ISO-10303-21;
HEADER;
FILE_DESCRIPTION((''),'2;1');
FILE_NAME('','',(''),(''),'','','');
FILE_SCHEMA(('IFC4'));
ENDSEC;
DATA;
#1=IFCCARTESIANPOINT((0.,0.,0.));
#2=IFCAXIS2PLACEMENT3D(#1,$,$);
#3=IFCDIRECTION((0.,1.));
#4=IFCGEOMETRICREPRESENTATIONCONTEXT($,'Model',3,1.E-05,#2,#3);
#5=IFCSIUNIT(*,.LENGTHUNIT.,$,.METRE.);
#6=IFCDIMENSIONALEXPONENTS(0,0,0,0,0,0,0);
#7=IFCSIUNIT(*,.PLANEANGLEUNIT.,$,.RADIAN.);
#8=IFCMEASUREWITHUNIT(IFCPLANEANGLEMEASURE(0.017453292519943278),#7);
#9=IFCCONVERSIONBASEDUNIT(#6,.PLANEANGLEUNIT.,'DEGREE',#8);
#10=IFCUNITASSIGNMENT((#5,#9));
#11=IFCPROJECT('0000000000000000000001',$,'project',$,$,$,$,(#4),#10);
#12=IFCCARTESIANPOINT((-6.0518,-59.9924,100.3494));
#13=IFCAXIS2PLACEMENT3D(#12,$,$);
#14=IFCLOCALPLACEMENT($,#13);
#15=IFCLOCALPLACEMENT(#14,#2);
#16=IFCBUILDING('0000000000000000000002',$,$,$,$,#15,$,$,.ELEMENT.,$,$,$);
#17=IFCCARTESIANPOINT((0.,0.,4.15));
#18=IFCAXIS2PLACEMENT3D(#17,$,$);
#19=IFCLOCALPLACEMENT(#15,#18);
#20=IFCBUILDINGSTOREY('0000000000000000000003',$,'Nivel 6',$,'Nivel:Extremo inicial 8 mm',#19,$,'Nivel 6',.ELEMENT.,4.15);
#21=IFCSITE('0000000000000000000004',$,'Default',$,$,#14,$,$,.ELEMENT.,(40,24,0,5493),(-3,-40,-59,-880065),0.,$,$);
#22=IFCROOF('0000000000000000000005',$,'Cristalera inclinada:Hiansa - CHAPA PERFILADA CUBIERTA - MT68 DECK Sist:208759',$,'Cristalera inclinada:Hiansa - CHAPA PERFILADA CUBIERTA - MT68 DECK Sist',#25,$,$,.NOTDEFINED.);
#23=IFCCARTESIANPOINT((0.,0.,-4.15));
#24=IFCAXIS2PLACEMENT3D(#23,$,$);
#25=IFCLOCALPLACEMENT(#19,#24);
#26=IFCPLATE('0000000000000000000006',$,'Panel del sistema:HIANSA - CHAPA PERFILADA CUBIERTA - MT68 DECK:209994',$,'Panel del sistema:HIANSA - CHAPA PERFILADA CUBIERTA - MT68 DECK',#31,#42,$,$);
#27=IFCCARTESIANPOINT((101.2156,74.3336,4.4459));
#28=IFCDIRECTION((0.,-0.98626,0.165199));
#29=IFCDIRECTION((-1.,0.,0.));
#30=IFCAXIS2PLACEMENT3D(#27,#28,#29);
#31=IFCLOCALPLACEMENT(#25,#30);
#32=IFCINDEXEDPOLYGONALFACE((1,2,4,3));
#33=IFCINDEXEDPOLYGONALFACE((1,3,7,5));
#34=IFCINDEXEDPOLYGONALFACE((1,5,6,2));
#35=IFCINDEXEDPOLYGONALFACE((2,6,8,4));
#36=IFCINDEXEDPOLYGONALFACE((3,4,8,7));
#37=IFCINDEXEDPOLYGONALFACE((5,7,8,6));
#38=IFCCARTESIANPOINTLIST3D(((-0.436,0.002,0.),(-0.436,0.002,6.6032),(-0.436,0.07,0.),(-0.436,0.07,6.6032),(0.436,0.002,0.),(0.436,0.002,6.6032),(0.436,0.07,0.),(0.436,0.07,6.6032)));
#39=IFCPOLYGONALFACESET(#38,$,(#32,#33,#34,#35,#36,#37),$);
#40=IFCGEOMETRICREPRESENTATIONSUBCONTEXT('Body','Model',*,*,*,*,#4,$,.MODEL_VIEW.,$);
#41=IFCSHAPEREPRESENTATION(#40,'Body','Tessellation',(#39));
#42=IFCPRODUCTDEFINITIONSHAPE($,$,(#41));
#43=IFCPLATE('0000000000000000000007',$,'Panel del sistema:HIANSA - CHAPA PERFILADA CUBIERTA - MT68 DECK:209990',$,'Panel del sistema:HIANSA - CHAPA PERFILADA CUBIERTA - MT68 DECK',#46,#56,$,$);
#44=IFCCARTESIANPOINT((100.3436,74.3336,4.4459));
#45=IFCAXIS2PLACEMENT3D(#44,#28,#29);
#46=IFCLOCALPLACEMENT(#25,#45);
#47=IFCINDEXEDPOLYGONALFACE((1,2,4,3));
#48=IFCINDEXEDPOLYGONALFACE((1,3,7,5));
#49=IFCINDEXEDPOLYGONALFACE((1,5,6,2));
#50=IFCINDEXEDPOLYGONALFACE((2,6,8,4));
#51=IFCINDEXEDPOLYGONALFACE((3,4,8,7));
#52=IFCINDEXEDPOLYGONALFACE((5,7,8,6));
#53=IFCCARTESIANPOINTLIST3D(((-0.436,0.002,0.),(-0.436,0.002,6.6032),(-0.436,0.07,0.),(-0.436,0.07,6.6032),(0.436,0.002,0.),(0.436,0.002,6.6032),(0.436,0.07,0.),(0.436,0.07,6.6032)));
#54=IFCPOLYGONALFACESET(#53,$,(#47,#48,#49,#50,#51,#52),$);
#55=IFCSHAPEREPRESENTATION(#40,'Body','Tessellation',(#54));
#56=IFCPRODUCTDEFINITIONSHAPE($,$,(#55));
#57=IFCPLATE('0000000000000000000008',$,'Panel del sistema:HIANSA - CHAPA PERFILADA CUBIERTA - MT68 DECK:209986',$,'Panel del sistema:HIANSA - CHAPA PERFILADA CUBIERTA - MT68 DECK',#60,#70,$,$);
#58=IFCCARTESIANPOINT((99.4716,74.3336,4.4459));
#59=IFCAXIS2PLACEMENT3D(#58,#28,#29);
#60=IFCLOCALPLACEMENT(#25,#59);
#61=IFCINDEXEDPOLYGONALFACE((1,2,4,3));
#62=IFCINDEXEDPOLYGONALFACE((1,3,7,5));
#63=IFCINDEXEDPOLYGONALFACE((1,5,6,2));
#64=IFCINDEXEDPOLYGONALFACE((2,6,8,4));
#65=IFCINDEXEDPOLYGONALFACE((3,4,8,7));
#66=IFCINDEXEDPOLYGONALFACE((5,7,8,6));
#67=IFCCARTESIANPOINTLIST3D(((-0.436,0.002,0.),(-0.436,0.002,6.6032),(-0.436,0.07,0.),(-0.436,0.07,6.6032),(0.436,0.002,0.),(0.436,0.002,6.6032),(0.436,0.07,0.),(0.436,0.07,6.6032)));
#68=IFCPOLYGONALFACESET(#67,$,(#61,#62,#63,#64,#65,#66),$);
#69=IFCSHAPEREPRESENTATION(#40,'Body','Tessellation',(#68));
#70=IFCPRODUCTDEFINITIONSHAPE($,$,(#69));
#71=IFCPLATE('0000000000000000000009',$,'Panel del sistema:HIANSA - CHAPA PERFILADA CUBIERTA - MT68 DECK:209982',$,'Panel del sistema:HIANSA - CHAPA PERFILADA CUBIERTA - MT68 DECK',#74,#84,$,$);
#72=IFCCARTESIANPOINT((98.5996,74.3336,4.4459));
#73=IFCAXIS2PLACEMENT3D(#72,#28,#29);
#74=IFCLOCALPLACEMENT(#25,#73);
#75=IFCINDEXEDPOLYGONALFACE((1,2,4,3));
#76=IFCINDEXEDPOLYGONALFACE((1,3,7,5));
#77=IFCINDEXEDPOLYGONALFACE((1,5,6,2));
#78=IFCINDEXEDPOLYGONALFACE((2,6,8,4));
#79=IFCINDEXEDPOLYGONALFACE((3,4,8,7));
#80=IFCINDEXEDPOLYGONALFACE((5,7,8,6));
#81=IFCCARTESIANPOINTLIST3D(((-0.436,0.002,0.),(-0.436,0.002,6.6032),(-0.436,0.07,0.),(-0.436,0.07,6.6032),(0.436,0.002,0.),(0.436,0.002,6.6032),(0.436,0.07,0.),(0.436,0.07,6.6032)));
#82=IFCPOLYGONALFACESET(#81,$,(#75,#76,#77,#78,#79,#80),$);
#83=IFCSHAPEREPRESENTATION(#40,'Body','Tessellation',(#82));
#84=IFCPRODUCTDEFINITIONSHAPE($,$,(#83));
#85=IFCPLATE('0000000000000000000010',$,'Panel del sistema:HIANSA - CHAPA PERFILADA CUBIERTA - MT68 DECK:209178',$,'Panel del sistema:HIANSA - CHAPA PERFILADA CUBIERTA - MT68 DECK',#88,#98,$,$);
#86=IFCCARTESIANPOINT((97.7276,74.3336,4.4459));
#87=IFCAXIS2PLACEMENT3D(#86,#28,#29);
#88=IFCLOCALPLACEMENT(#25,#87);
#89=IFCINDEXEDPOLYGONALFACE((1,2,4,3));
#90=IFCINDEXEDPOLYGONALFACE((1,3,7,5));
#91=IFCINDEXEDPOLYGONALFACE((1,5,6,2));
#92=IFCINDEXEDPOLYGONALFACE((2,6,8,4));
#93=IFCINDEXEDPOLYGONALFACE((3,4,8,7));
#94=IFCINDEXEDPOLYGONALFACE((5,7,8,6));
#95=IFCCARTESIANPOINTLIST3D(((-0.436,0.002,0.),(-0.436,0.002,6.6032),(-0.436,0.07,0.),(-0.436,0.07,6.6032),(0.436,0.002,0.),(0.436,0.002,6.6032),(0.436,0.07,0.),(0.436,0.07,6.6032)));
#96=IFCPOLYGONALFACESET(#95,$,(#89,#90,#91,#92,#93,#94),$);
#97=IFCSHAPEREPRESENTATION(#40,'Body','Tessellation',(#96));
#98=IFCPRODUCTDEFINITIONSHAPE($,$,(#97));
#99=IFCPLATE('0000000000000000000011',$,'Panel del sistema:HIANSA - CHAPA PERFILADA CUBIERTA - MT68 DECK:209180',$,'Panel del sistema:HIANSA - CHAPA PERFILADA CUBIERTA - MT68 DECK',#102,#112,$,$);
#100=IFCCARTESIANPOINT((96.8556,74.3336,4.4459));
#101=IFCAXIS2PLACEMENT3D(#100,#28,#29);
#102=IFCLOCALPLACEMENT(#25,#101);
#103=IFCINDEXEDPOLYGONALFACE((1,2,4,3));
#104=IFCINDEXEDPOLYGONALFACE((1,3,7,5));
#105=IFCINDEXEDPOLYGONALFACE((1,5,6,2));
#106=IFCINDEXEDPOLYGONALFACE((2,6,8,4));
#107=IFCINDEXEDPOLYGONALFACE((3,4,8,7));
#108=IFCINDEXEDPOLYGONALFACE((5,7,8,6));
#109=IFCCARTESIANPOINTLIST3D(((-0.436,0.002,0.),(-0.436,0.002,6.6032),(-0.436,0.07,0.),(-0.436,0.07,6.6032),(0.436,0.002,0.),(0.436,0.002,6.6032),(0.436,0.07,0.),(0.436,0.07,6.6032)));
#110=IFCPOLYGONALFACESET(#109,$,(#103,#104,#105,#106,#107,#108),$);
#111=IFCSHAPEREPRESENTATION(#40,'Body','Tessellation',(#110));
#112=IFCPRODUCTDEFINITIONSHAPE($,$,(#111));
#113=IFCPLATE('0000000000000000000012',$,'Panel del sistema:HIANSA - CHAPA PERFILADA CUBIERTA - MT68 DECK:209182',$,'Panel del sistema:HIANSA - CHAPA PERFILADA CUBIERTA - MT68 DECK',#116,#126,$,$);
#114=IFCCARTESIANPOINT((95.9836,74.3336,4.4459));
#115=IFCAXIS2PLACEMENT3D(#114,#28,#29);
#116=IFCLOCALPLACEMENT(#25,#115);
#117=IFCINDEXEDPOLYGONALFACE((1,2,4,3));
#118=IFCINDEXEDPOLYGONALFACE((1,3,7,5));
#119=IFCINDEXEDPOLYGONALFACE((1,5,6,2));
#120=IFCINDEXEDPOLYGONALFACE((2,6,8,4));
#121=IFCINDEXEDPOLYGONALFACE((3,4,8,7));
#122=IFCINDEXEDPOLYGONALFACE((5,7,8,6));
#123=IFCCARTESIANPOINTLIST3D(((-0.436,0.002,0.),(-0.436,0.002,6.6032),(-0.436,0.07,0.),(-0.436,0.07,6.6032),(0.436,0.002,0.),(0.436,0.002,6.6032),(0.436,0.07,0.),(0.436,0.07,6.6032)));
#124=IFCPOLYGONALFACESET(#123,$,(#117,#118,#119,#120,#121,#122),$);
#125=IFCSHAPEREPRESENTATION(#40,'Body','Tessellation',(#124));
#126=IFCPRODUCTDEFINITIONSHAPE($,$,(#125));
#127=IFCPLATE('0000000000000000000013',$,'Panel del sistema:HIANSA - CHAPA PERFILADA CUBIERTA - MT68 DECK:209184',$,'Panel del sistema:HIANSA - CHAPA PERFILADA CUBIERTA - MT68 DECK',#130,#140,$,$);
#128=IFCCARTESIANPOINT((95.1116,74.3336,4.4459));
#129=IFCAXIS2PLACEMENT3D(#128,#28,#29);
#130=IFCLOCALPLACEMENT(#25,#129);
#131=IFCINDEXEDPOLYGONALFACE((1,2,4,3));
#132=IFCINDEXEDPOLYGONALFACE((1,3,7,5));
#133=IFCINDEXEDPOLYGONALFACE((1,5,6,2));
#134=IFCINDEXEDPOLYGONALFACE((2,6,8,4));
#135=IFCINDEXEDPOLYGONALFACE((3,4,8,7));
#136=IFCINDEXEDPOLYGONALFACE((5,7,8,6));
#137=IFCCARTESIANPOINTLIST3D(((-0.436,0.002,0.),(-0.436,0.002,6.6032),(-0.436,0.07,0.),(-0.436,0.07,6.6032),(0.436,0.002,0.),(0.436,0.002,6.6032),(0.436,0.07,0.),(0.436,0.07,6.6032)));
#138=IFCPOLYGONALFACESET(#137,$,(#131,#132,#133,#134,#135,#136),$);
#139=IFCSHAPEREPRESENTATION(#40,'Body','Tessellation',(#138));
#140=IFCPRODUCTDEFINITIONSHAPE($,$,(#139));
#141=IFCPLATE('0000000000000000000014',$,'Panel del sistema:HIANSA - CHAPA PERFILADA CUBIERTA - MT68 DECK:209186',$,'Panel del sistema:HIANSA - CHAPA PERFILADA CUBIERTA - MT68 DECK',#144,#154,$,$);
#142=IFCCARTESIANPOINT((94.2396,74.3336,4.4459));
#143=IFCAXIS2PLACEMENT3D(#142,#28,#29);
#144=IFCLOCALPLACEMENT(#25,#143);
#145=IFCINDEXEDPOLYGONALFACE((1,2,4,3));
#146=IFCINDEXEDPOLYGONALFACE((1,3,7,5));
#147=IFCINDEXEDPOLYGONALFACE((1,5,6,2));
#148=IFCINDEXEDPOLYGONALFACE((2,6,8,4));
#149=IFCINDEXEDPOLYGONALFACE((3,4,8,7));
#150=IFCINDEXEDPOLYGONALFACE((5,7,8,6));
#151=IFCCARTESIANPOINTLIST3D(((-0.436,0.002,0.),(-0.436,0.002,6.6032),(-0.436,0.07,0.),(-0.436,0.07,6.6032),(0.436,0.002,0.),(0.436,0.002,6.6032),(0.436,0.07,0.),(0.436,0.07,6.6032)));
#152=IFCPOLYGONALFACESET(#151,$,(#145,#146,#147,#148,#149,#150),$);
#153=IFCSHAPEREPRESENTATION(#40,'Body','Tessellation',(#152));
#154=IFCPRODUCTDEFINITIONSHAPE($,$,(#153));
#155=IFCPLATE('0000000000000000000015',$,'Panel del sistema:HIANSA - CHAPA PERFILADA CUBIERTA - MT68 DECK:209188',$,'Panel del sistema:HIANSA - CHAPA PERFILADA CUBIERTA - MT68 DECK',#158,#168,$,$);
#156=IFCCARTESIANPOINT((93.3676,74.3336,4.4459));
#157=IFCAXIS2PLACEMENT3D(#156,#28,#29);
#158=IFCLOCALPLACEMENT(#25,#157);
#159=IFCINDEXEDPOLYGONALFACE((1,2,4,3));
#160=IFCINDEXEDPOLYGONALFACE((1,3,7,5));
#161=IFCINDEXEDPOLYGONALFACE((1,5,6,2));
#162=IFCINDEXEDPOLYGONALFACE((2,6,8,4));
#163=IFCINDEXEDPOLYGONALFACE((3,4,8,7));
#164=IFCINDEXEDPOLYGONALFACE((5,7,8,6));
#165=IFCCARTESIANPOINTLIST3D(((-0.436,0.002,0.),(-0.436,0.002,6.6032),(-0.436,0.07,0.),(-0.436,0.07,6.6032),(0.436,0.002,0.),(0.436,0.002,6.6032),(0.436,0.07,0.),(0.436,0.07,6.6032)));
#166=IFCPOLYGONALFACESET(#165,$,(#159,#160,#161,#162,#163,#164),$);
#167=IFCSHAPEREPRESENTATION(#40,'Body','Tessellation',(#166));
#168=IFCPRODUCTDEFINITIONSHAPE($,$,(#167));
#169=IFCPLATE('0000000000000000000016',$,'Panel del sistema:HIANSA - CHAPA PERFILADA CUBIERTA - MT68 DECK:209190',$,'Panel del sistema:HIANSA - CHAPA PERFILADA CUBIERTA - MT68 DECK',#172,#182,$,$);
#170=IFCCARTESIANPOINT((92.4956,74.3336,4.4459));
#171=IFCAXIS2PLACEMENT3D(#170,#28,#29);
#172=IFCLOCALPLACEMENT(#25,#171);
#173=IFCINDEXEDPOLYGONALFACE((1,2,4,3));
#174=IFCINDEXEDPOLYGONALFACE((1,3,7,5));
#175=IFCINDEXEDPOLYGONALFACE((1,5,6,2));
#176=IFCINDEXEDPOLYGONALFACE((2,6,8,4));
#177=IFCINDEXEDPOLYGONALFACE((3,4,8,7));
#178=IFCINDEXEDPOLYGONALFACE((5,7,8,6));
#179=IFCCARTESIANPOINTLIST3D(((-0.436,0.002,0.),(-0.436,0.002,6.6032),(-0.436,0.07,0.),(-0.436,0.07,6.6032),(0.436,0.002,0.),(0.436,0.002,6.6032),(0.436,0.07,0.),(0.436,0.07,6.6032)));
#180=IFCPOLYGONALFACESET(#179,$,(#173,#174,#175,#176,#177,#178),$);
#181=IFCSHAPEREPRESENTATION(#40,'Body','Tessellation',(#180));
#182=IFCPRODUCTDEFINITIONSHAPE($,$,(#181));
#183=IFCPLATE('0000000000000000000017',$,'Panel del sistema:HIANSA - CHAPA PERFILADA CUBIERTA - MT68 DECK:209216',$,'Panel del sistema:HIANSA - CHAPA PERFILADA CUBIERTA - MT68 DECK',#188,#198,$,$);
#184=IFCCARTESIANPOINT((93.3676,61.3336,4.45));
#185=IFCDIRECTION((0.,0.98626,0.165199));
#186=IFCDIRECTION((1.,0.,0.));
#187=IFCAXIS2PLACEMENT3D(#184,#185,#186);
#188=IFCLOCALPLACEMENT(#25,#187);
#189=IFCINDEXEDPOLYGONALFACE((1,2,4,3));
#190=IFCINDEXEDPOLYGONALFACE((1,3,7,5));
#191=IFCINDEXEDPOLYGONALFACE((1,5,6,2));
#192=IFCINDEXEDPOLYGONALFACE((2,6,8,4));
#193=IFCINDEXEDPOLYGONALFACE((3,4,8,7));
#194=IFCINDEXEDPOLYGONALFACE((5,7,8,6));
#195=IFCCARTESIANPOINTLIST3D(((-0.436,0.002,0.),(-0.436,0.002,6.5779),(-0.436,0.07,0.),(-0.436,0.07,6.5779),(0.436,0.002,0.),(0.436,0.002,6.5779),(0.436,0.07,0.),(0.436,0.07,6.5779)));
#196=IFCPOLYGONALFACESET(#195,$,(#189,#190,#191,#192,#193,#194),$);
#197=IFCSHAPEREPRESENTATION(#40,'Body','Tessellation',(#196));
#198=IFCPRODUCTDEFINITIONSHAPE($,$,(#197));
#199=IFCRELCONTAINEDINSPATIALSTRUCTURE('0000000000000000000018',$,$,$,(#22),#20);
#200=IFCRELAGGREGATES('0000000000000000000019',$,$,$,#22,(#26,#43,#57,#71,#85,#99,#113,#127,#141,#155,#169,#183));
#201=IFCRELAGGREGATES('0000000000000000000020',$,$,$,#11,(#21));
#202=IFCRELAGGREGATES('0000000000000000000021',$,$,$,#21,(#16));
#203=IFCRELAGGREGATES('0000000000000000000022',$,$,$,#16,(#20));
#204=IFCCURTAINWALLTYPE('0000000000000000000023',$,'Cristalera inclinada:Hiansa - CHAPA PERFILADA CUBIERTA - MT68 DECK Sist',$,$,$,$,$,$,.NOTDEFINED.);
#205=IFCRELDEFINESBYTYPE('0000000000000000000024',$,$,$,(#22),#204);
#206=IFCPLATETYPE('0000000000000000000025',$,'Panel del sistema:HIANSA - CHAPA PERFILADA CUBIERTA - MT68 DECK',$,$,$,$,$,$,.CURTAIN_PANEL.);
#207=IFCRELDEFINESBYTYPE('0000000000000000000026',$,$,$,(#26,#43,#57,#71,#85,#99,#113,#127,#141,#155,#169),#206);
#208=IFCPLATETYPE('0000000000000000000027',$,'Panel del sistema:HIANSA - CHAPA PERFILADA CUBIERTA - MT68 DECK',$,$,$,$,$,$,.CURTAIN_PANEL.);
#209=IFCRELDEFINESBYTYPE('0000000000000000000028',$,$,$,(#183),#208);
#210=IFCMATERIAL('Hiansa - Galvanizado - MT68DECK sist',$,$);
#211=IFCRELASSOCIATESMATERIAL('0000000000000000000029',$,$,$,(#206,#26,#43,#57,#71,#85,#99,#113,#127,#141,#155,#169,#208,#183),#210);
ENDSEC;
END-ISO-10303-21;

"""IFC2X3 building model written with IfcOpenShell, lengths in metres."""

from ifc_helpers import new_model, entity, si_unit, converted_unit, direction, frame, origin, origin_2d_with_axis, place, context, subcontext, project, spatial, rectangle, extrude, source, transform, mapped, material, type_object, type_shapes, element, aggregate, save


model = new_model("IFC2X3")

# Units and contexts
model_context = context("Model", 3, precision=1e-05, world=origin(), true_north=direction((0.0, 1.0)))
body_context = subcontext(model_context, "Body", "Model", "MODEL_VIEW")
ifc_project = project(units=[si_unit("LENGTHUNIT", "METRE"), converted_unit("PLANEANGLEUNIT", "DEGREE", entity("IfcPlaneAngleMeasure", 0.017453292519943278), si_unit("PLANEANGLEUNIT", "RADIAN"), dimensions=[0, 0, 0, 0, 0, 0, 0])], contexts=[model_context])

# Site, building, storey
site_placement = place(None, frame((-6.0518, -59.9924, 100.3494)))
site = spatial("IfcSite", under=ifc_project, at=site_placement, Name="Default", CompositionType="ELEMENT", RefLatitude=(40, 24, 0, 5493), RefLongitude=(-3, -40, -59, -880065), RefElevation=0.0)
building_placement = place(site_placement, origin())
building = spatial("IfcBuilding", under=site, at=building_placement, CompositionType="ELEMENT")
storey_placement = place(building_placement, frame((0.0, 0.0, 4.15)))
storey = spatial("IfcBuildingStorey", under=building, at=storey_placement, Name="Nivel 6", ObjectType="Nivel:Extremo inicial 8 mm", LongName="Nivel 6", CompositionType="ELEMENT", Elevation=4.15)

# Roof, plates
curtain_wall_type = type_object("IfcCurtainWallType", Name="Cristalera inclinada:Hiansa - CHAPA PERFILADA CUBIERTA - MT68 DECK Sist", PredefinedType="NOTDEFINED")
roof_placement = place(storey_placement, frame((0.0, 0.0, -4.15)))
roof = element("IfcRoof", 1, at=roof_placement, inside=storey, type_object=curtain_wall_type, Name="Cristalera inclinada:Hiansa - CHAPA PERFILADA CUBIERTA - MT68 DECK Sist:208759", ObjectType="Cristalera inclinada:Hiansa - CHAPA PERFILADA CUBIERTA - MT68 DECK Sist", ShapeType="NOTDEFINED")
ifc_material_1 = material(Name="Hiansa - Galvanizado - MT68DECK sist")
plate_type_1 = type_object("IfcPlateType", Name="Panel del sistema:HIANSA - CHAPA PERFILADA CUBIERTA - MT68 DECK", PredefinedType="CURTAIN_PANEL", material=ifc_material_1)
shared_shape_1 = source(origin(), body_context, "Body", "SweptSolid", [
    extrude(rectangle(XDim=0.068, YDim=0.872, at=origin_2d_with_axis()), frame((0.0, 0.036, 0.0), z_axis=(0.0, 0.0, 1.0), x_axis=(0.0, 1.0, 0.0)), (0.0, 0.0, 1.0), 6.6032),
])
type_shapes(plate_type_1, [shared_shape_1])
plate_1_placement = place(roof_placement, frame((101.2156, 74.3336, 4.4459), z_axis=(0.0, -0.98626, 0.165199), x_axis=(-1.0, 0.0, 0.0)))
plate_1 = element("IfcPlate", 2, at=plate_1_placement, type_object=plate_type_1, material=ifc_material_1, Name="Panel del sistema:HIANSA - CHAPA PERFILADA CUBIERTA - MT68 DECK:209994", ObjectType="Panel del sistema:HIANSA - CHAPA PERFILADA CUBIERTA - MT68 DECK", context=body_context, shape_type="MappedRepresentation", body=[
    mapped(shared_shape_1, transform((0.0, 0.0, 0.0), scale=1.0)),
])
plate_2_placement = place(roof_placement, frame((100.3436, 74.3336, 4.4459), z_axis=(0.0, -0.98626, 0.165199), x_axis=(-1.0, 0.0, 0.0)))
plate_2 = element("IfcPlate", 3, at=plate_2_placement, type_object=plate_type_1, material=ifc_material_1, Name="Panel del sistema:HIANSA - CHAPA PERFILADA CUBIERTA - MT68 DECK:209990", ObjectType="Panel del sistema:HIANSA - CHAPA PERFILADA CUBIERTA - MT68 DECK", context=body_context, shape_type="MappedRepresentation", body=[
    mapped(shared_shape_1, transform((0.0, 0.0, 0.0), scale=1.0)),
])
plate_3_placement = place(roof_placement, frame((99.4716, 74.3336, 4.4459), z_axis=(0.0, -0.98626, 0.165199), x_axis=(-1.0, 0.0, 0.0)))
plate_3 = element("IfcPlate", 4, at=plate_3_placement, type_object=plate_type_1, material=ifc_material_1, Name="Panel del sistema:HIANSA - CHAPA PERFILADA CUBIERTA - MT68 DECK:209986", ObjectType="Panel del sistema:HIANSA - CHAPA PERFILADA CUBIERTA - MT68 DECK", context=body_context, shape_type="MappedRepresentation", body=[
    mapped(shared_shape_1, transform((0.0, 0.0, 0.0), scale=1.0)),
])
plate_4_placement = place(roof_placement, frame((98.5996, 74.3336, 4.4459), z_axis=(0.0, -0.98626, 0.165199), x_axis=(-1.0, 0.0, 0.0)))
plate_4 = element("IfcPlate", 5, at=plate_4_placement, type_object=plate_type_1, material=ifc_material_1, Name="Panel del sistema:HIANSA - CHAPA PERFILADA CUBIERTA - MT68 DECK:209982", ObjectType="Panel del sistema:HIANSA - CHAPA PERFILADA CUBIERTA - MT68 DECK", context=body_context, shape_type="MappedRepresentation", body=[
    mapped(shared_shape_1, transform((0.0, 0.0, 0.0), scale=1.0)),
])
plate_5_placement = place(roof_placement, frame((97.7276, 74.3336, 4.4459), z_axis=(0.0, -0.98626, 0.165199), x_axis=(-1.0, 0.0, 0.0)))
plate_5 = element("IfcPlate", 6, at=plate_5_placement, type_object=plate_type_1, material=ifc_material_1, Name="Panel del sistema:HIANSA - CHAPA PERFILADA CUBIERTA - MT68 DECK:209178", ObjectType="Panel del sistema:HIANSA - CHAPA PERFILADA CUBIERTA - MT68 DECK", context=body_context, shape_type="MappedRepresentation", body=[
    mapped(shared_shape_1, transform((0.0, 0.0, 0.0), scale=1.0)),
])
plate_6_placement = place(roof_placement, frame((96.8556, 74.3336, 4.4459), z_axis=(0.0, -0.98626, 0.165199), x_axis=(-1.0, 0.0, 0.0)))
plate_6 = element("IfcPlate", 7, at=plate_6_placement, type_object=plate_type_1, material=ifc_material_1, Name="Panel del sistema:HIANSA - CHAPA PERFILADA CUBIERTA - MT68 DECK:209180", ObjectType="Panel del sistema:HIANSA - CHAPA PERFILADA CUBIERTA - MT68 DECK", context=body_context, shape_type="MappedRepresentation", body=[
    mapped(shared_shape_1, transform((0.0, 0.0, 0.0), scale=1.0)),
])
plate_7_placement = place(roof_placement, frame((95.9836, 74.3336, 4.4459), z_axis=(0.0, -0.98626, 0.165199), x_axis=(-1.0, 0.0, 0.0)))
plate_7 = element("IfcPlate", 8, at=plate_7_placement, type_object=plate_type_1, material=ifc_material_1, Name="Panel del sistema:HIANSA - CHAPA PERFILADA CUBIERTA - MT68 DECK:209182", ObjectType="Panel del sistema:HIANSA - CHAPA PERFILADA CUBIERTA - MT68 DECK", context=body_context, shape_type="MappedRepresentation", body=[
    mapped(shared_shape_1, transform((0.0, 0.0, 0.0), scale=1.0)),
])
plate_8_placement = place(roof_placement, frame((95.1116, 74.3336, 4.4459), z_axis=(0.0, -0.98626, 0.165199), x_axis=(-1.0, 0.0, 0.0)))
plate_8 = element("IfcPlate", 9, at=plate_8_placement, type_object=plate_type_1, material=ifc_material_1, Name="Panel del sistema:HIANSA - CHAPA PERFILADA CUBIERTA - MT68 DECK:209184", ObjectType="Panel del sistema:HIANSA - CHAPA PERFILADA CUBIERTA - MT68 DECK", context=body_context, shape_type="MappedRepresentation", body=[
    mapped(shared_shape_1, transform((0.0, 0.0, 0.0), scale=1.0)),
])
plate_9_placement = place(roof_placement, frame((94.2396, 74.3336, 4.4459), z_axis=(0.0, -0.98626, 0.165199), x_axis=(-1.0, 0.0, 0.0)))
plate_9 = element("IfcPlate", 10, at=plate_9_placement, type_object=plate_type_1, material=ifc_material_1, Name="Panel del sistema:HIANSA - CHAPA PERFILADA CUBIERTA - MT68 DECK:209186", ObjectType="Panel del sistema:HIANSA - CHAPA PERFILADA CUBIERTA - MT68 DECK", context=body_context, shape_type="MappedRepresentation", body=[
    mapped(shared_shape_1, transform((0.0, 0.0, 0.0), scale=1.0)),
])
plate_10_placement = place(roof_placement, frame((93.3676, 74.3336, 4.4459), z_axis=(0.0, -0.98626, 0.165199), x_axis=(-1.0, 0.0, 0.0)))
plate_10 = element("IfcPlate", 11, at=plate_10_placement, type_object=plate_type_1, material=ifc_material_1, Name="Panel del sistema:HIANSA - CHAPA PERFILADA CUBIERTA - MT68 DECK:209188", ObjectType="Panel del sistema:HIANSA - CHAPA PERFILADA CUBIERTA - MT68 DECK", context=body_context, shape_type="MappedRepresentation", body=[
    mapped(shared_shape_1, transform((0.0, 0.0, 0.0), scale=1.0)),
])
plate_11_placement = place(roof_placement, frame((92.4956, 74.3336, 4.4459), z_axis=(0.0, -0.98626, 0.165199), x_axis=(-1.0, 0.0, 0.0)))
plate_11 = element("IfcPlate", 12, at=plate_11_placement, type_object=plate_type_1, material=ifc_material_1, Name="Panel del sistema:HIANSA - CHAPA PERFILADA CUBIERTA - MT68 DECK:209190", ObjectType="Panel del sistema:HIANSA - CHAPA PERFILADA CUBIERTA - MT68 DECK", context=body_context, shape_type="MappedRepresentation", body=[
    mapped(shared_shape_1, transform((0.0, 0.0, 0.0), scale=1.0)),
])
plate_type_2 = type_object("IfcPlateType", Name="Panel del sistema:HIANSA - CHAPA PERFILADA CUBIERTA - MT68 DECK", PredefinedType="CURTAIN_PANEL", material=ifc_material_1)
shared_shape_2 = source(origin(), body_context, "Body", "SweptSolid", [
    extrude(rectangle(XDim=0.068, YDim=0.872, at=origin_2d_with_axis()), frame((0.0, 0.036, 0.0), z_axis=(0.0, 0.0, 1.0), x_axis=(0.0, 1.0, 0.0)), (0.0, 0.0, 1.0), 6.5779),
])
type_shapes(plate_type_2, [shared_shape_2])
plate_12_placement = place(roof_placement, frame((93.3676, 61.3336, 4.45), z_axis=(0.0, 0.98626, 0.165199), x_axis=(1.0, 0.0, 0.0)))
plate_12 = element("IfcPlate", 13, at=plate_12_placement, type_object=plate_type_2, material=ifc_material_1, Name="Panel del sistema:HIANSA - CHAPA PERFILADA CUBIERTA - MT68 DECK:209216", ObjectType="Panel del sistema:HIANSA - CHAPA PERFILADA CUBIERTA - MT68 DECK", context=body_context, shape_type="MappedRepresentation", body=[
    mapped(shared_shape_2, transform((0.0, 0.0, 0.0), scale=1.0)),
])
aggregate(roof, [plate_1, plate_2, plate_3, plate_4, plate_5, plate_6, plate_7, plate_8, plate_9, plate_10, plate_11, plate_12])

save(model, "model.ifc")
